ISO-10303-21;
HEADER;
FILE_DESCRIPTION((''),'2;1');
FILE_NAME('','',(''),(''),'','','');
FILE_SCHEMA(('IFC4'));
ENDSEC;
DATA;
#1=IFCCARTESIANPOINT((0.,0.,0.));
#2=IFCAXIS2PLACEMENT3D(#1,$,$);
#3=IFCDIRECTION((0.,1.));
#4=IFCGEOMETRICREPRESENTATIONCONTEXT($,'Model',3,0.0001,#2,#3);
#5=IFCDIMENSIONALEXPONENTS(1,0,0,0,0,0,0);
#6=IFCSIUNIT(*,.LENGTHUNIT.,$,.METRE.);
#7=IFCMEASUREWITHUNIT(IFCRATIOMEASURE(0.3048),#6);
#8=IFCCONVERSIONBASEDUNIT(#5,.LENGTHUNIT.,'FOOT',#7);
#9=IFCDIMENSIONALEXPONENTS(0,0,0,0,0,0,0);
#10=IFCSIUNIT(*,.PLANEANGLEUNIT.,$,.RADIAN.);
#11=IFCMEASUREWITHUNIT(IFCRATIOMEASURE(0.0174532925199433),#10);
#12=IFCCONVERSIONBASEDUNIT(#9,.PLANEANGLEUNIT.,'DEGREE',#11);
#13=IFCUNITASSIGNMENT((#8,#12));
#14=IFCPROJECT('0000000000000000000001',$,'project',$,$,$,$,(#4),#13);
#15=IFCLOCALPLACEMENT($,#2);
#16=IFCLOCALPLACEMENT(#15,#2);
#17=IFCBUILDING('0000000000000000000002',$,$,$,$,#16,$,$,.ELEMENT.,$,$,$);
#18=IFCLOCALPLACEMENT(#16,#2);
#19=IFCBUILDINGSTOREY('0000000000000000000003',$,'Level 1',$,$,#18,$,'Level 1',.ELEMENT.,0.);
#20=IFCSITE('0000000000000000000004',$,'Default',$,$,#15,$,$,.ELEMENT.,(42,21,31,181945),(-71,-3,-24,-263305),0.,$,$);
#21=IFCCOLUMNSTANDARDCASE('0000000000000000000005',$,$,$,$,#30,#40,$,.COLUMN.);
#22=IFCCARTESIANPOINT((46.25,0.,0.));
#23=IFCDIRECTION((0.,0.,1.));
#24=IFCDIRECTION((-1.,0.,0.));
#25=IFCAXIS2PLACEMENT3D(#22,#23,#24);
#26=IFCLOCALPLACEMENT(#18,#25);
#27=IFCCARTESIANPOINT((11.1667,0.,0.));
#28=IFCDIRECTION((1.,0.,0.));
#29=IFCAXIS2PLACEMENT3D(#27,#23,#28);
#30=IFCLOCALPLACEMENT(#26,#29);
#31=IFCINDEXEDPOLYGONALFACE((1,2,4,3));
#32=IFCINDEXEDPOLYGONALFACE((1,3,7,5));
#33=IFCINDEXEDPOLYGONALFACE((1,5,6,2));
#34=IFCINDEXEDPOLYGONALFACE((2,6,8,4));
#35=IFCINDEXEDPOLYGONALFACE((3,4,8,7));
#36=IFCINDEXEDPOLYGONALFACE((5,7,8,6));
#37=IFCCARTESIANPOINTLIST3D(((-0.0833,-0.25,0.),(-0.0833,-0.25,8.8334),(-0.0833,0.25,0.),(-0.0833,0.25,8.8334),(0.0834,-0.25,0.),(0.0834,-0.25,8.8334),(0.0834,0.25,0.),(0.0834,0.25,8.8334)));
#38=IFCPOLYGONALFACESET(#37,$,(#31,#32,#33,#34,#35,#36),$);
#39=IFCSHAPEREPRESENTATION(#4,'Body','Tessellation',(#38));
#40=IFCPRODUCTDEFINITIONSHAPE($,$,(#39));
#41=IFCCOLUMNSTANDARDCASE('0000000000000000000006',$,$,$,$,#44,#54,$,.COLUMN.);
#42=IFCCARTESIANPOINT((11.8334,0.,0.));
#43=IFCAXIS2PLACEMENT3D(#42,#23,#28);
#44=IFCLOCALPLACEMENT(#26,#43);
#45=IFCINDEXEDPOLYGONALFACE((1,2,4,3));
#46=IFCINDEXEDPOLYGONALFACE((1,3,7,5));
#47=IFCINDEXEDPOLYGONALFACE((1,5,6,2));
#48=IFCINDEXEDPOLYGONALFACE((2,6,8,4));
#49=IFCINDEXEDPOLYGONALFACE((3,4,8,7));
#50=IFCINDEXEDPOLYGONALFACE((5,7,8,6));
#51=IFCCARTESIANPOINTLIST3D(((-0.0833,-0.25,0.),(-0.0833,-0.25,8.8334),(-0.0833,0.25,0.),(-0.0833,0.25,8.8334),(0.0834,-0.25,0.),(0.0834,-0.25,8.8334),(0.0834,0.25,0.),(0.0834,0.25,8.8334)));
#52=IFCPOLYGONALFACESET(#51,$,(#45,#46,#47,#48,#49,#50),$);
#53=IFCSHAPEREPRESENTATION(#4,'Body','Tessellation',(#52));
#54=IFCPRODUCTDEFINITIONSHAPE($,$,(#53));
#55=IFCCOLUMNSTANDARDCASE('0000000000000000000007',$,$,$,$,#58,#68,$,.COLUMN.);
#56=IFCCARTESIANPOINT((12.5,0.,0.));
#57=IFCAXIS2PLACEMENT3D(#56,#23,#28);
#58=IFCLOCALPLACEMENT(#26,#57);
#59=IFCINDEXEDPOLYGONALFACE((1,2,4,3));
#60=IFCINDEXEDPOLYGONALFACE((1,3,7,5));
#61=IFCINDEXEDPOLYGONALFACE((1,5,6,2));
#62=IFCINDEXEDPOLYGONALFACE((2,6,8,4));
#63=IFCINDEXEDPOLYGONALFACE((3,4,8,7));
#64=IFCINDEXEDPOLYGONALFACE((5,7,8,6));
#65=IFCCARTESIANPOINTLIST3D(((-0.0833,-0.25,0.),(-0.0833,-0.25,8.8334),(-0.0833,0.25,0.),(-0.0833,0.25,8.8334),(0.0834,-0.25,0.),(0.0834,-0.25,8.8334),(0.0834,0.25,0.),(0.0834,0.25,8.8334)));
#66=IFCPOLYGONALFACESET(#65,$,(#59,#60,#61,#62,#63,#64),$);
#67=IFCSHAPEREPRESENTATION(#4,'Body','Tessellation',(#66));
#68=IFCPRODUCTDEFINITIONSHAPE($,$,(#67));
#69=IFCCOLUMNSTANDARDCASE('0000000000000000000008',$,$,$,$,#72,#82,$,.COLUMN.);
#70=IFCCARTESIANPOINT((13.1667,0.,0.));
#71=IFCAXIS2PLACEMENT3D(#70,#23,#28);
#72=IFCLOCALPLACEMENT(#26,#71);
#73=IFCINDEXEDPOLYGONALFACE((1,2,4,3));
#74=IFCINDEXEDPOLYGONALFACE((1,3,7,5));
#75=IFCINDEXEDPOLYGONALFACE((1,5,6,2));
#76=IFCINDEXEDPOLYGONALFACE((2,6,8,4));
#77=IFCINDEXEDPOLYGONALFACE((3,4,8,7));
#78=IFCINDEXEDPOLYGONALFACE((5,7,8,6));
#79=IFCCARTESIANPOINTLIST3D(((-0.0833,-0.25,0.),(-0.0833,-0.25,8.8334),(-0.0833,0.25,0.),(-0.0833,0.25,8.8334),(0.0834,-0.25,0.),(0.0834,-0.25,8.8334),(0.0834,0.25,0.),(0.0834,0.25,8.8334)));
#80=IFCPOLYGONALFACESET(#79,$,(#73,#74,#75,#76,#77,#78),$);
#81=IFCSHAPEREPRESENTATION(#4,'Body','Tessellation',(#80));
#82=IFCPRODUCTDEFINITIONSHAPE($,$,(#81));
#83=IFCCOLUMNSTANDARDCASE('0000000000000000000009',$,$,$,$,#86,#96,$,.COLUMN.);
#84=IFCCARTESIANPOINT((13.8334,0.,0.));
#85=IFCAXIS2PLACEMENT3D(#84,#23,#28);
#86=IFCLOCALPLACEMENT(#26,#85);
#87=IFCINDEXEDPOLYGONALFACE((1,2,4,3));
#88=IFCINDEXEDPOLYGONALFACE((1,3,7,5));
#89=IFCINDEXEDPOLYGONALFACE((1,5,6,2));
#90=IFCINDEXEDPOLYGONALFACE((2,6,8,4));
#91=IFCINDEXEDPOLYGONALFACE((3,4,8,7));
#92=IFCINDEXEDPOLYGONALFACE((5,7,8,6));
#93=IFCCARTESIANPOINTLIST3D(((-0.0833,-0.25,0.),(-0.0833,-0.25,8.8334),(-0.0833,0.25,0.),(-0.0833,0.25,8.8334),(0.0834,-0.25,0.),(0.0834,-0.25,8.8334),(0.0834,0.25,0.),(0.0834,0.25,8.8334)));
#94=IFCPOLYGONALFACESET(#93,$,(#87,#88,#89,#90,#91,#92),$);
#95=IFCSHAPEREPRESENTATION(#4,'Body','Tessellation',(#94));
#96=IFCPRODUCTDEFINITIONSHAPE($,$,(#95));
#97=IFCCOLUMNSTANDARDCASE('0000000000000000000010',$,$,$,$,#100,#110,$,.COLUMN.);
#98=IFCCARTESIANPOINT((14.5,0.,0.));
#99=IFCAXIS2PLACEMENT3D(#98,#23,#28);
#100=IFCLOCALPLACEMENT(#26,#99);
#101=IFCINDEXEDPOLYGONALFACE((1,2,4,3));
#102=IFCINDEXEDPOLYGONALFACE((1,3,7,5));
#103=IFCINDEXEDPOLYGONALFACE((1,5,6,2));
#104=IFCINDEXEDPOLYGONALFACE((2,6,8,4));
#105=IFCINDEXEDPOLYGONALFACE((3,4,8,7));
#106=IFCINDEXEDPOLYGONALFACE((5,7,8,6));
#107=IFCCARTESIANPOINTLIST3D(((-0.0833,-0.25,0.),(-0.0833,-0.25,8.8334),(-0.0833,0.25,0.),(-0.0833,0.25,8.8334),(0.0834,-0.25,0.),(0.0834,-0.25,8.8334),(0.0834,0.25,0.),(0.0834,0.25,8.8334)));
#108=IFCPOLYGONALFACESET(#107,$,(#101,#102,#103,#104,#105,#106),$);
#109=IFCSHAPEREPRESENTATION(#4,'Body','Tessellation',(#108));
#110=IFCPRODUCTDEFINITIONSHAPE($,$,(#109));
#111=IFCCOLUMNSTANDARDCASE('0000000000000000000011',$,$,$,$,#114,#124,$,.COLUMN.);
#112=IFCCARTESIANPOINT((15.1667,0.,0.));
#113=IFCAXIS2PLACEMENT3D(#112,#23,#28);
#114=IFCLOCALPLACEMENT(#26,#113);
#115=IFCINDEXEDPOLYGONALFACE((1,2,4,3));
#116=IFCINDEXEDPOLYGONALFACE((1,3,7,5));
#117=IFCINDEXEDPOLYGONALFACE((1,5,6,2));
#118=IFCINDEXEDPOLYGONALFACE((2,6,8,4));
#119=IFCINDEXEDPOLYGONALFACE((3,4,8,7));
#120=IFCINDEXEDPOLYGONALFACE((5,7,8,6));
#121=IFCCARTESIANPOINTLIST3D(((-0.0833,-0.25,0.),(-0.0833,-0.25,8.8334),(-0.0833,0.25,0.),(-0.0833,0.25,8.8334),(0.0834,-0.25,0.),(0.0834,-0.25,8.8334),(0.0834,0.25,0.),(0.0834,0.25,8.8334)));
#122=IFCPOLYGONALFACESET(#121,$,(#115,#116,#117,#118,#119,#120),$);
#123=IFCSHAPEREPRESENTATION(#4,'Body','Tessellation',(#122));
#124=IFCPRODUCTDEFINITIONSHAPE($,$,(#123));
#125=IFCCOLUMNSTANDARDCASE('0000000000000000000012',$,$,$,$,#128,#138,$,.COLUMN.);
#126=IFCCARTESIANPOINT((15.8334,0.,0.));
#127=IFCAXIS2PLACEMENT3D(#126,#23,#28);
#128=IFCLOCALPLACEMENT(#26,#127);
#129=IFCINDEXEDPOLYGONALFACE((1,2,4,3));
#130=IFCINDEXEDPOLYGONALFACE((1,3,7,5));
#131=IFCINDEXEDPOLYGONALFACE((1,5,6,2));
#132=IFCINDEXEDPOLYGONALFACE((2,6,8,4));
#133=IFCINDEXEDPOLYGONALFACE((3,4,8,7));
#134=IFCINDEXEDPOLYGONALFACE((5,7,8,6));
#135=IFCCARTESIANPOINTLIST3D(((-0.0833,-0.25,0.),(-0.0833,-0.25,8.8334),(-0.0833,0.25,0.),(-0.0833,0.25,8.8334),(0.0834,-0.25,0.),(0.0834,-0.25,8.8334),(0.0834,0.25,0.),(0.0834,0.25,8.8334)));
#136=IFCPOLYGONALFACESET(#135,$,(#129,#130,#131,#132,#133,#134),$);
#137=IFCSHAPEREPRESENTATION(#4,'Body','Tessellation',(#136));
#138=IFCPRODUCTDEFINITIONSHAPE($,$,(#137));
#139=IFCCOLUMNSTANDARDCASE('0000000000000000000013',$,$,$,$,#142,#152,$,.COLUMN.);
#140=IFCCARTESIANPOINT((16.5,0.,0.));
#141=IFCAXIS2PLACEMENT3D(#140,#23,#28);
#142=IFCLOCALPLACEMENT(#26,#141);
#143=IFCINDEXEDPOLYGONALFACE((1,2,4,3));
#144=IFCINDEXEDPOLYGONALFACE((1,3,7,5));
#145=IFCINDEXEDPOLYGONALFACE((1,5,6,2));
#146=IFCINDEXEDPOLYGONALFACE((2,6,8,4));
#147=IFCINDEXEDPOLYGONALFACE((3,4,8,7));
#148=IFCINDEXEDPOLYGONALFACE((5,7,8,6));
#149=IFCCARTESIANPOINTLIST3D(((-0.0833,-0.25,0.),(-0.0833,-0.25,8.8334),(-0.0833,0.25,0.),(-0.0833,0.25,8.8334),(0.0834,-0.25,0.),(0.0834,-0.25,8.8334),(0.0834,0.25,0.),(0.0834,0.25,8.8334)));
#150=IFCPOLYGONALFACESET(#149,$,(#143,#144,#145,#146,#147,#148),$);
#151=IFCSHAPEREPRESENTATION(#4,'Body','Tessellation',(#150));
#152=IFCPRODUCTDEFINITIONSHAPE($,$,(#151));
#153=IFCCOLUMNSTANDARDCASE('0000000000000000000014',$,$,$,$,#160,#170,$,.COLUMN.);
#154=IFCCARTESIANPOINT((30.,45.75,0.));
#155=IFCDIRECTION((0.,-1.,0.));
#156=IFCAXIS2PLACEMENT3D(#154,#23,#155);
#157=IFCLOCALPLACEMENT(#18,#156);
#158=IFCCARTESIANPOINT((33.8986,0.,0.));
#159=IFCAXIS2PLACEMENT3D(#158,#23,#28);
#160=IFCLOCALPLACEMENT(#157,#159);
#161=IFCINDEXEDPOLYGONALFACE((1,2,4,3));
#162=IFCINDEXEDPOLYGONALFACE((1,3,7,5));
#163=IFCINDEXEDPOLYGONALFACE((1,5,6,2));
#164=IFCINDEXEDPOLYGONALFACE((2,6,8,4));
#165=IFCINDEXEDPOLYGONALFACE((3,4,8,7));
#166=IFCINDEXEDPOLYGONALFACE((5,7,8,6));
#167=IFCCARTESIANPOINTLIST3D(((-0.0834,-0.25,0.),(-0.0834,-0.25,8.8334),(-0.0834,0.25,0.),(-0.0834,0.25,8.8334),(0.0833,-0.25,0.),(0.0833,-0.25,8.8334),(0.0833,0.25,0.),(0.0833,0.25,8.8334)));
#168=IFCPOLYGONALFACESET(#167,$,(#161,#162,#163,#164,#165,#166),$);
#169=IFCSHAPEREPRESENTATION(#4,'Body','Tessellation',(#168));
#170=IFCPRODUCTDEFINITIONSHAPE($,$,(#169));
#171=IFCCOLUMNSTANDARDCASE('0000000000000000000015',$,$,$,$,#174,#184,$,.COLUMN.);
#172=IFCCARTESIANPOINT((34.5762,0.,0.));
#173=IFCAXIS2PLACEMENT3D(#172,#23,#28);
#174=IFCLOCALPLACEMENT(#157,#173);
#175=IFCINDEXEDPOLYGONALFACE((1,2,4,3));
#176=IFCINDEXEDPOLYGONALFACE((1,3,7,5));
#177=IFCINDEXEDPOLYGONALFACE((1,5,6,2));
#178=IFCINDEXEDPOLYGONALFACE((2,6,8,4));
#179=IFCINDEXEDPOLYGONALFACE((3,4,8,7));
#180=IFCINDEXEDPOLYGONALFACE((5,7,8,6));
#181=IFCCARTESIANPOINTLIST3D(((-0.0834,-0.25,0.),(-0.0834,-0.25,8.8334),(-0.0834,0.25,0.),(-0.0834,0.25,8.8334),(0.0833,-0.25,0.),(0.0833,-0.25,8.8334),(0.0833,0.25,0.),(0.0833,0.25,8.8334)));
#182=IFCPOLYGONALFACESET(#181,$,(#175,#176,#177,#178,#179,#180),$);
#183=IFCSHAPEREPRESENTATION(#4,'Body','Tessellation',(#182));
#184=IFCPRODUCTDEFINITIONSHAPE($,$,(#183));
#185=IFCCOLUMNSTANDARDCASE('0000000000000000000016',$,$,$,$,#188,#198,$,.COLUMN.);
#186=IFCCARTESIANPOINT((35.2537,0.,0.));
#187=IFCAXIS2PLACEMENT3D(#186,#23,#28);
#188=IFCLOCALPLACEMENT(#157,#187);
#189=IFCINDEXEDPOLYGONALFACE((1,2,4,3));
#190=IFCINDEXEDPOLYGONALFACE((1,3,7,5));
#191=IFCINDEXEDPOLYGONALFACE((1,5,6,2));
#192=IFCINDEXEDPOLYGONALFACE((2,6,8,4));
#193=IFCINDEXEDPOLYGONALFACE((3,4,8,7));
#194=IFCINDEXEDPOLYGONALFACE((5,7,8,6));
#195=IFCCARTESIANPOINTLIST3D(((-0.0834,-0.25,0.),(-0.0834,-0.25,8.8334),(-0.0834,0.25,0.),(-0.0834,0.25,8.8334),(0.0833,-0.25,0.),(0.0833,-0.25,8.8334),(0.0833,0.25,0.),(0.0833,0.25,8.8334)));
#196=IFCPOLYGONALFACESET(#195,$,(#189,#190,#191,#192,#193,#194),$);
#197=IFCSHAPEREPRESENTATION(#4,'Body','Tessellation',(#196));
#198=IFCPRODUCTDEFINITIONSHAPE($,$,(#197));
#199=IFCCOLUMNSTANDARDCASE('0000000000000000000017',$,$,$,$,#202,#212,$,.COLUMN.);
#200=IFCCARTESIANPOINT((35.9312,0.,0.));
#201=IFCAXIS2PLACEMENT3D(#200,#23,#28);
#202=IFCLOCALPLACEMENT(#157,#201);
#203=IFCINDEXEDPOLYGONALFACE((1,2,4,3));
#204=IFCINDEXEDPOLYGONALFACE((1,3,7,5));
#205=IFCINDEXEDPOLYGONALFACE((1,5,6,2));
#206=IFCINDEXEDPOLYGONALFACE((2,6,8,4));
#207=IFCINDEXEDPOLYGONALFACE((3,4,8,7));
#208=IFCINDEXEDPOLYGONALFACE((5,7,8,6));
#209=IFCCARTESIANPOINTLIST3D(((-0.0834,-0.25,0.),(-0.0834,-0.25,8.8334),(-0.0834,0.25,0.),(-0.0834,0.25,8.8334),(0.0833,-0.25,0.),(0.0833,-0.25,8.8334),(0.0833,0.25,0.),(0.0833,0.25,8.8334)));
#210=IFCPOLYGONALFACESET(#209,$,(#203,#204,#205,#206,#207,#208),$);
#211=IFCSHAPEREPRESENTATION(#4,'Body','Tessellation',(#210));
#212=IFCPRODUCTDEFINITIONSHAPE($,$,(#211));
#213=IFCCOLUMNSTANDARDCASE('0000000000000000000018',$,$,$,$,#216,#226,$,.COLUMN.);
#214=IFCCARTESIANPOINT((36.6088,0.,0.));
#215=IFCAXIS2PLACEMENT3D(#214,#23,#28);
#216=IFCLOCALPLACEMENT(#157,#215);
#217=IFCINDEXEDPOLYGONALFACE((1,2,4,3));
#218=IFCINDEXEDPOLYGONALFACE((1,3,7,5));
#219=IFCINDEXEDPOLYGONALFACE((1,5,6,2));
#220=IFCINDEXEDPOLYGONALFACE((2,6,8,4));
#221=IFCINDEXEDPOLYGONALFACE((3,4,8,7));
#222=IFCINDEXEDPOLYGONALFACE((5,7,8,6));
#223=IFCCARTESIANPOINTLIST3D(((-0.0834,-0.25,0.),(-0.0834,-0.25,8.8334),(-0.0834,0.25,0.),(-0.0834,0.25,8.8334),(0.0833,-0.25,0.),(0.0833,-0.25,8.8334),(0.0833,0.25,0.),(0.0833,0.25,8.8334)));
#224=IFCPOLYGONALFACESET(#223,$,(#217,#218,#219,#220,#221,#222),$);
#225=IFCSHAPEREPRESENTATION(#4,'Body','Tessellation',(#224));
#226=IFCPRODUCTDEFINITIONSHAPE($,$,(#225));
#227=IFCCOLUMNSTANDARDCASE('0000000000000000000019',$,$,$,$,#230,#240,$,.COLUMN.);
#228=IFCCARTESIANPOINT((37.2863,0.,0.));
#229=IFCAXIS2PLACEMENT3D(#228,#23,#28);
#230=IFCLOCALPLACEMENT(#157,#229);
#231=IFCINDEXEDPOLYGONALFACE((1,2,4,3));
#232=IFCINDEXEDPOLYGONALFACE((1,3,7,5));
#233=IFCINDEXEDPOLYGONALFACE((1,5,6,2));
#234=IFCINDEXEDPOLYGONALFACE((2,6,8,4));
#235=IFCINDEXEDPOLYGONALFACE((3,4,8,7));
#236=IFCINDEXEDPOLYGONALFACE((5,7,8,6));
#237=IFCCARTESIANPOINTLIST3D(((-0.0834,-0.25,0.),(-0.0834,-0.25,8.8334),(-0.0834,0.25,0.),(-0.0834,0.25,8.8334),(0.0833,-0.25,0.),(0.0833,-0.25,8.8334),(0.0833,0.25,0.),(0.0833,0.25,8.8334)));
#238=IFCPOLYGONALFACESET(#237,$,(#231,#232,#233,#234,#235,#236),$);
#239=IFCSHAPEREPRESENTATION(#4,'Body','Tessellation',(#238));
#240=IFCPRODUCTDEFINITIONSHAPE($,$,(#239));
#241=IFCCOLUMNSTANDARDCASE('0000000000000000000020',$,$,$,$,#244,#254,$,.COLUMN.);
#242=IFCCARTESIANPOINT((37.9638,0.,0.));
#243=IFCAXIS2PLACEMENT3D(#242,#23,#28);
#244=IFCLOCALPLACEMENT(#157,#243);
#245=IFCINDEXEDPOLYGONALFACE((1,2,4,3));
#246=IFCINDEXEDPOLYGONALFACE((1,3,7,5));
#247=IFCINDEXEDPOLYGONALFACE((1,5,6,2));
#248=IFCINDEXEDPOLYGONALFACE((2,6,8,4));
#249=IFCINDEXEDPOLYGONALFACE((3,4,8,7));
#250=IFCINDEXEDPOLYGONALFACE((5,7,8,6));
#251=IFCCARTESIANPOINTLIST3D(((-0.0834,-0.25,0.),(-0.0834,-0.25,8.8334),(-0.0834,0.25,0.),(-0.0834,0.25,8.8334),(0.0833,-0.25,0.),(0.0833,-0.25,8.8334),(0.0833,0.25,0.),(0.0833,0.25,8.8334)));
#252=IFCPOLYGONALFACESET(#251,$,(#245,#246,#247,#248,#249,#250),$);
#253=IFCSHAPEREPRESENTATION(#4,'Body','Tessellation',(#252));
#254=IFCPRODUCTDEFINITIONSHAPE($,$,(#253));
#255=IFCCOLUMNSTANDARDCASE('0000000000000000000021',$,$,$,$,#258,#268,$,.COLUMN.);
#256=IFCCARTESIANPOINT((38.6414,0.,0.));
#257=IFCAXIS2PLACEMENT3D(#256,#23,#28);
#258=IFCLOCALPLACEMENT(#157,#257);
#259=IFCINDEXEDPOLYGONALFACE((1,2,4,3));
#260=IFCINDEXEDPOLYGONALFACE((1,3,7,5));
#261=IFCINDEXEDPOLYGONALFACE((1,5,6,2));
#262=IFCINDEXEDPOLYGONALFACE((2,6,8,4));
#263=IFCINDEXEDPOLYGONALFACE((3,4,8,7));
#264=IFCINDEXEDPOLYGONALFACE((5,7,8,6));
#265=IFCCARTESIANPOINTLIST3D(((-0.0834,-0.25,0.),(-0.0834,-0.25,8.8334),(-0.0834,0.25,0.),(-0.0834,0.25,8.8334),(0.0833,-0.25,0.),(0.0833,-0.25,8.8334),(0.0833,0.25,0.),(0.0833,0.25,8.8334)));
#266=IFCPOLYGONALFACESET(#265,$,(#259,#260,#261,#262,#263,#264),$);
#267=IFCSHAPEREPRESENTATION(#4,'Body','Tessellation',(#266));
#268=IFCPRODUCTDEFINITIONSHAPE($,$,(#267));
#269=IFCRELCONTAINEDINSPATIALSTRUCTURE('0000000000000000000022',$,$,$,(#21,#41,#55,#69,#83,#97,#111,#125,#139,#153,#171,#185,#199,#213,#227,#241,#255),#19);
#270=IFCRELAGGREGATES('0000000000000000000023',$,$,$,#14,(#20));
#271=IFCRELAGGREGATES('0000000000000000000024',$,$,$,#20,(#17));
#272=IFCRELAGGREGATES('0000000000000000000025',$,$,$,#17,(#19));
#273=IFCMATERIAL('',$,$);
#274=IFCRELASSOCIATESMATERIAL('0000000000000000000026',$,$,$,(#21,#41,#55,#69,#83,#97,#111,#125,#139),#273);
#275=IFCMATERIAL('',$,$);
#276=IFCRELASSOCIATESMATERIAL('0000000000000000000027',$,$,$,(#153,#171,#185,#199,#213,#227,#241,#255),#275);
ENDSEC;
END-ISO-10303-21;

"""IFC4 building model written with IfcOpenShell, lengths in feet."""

from ifc_helpers import new_model, entity, si_unit, converted_unit, direction, frame, origin, place, context, project, spatial, rectangle, extrude, material, element, save


model = new_model("IFC4")

# Units and contexts
model_context = context("Model", 3, precision=0.0001, world=origin(), true_north=direction((0.0, 1.0)))
ifc_project = project(units=[converted_unit("LENGTHUNIT", "FOOT", entity("IfcRatioMeasure", 0.3048), si_unit("LENGTHUNIT", "METRE"), dimensions=[1, 0, 0, 0, 0, 0, 0]), converted_unit("PLANEANGLEUNIT", "DEGREE", entity("IfcRatioMeasure", 0.0174532925199433), si_unit("PLANEANGLEUNIT", "RADIAN"), dimensions=[0, 0, 0, 0, 0, 0, 0])], contexts=[model_context])

# Site, building, storey
site_placement = place(None, origin())
site = spatial("IfcSite", under=ifc_project, at=site_placement, Name="Default", CompositionType="ELEMENT", RefLatitude=(42, 21, 31, 181945), RefLongitude=(-71, -3, -24, -263305), RefElevation=0.0)
building_placement = place(site_placement, origin())
building = spatial("IfcBuilding", under=site, at=building_placement, CompositionType="ELEMENT")
storey_placement = place(building_placement, origin())
storey = spatial("IfcBuildingStorey", under=building, at=storey_placement, Name="Level 1", LongName="Level 1", CompositionType="ELEMENT", Elevation=0.0)

# Columns
ifc_material_1 = material(Name="")
placement_1 = place(storey_placement, frame((46.25, 0.0, 0.0), z_axis=(0.0, 0.0, 1.0), x_axis=(-1.0, 0.0, 0.0)))
for number, where, z_axis, x_axis in (
    (1, (11.1667, 0.0, 0.0), (0.0, 0.0, 1.0), (1.0, 0.0, 0.0)),
    (2, (11.8334, 0.0, 0.0), (0.0, 0.0, 1.0), (1.0, 0.0, 0.0)),
    (3, (12.5, 0.0, 0.0), (0.0, 0.0, 1.0), (1.0, 0.0, 0.0)),
    (4, (13.1667, 0.0, 0.0), (0.0, 0.0, 1.0), (1.0, 0.0, 0.0)),
    (5, (13.8334, 0.0, 0.0), (0.0, 0.0, 1.0), (1.0, 0.0, 0.0)),
    (6, (14.5, 0.0, 0.0), (0.0, 0.0, 1.0), (1.0, 0.0, 0.0)),
    (7, (15.1667, 0.0, 0.0), (0.0, 0.0, 1.0), (1.0, 0.0, 0.0)),
    (8, (15.8334, 0.0, 0.0), (0.0, 0.0, 1.0), (1.0, 0.0, 0.0)),
    (9, (16.5, 0.0, 0.0), (0.0, 0.0, 1.0), (1.0, 0.0, 0.0)),
):
    element("IfcColumnStandardCase", number, at=place(placement_1, frame(where, z_axis=z_axis, x_axis=x_axis)), inside=storey, material=ifc_material_1, PredefinedType="COLUMN", context=model_context, shape_type="SweptSolid", body=[
        extrude(rectangle(XDim=0.1667, YDim=0.5), origin(), (0.0, 0.0, 1.0), 8.8334),
    ])
ifc_material_2 = material(Name="")
placement_2 = place(storey_placement, frame((30.0, 45.75, 0.0), z_axis=(0.0, 0.0, 1.0), x_axis=(0.0, -1.0, 0.0)))
for number, where, z_axis, x_axis in (
    (10, (33.8986, 0.0, 0.0), (0.0, 0.0, 1.0), (1.0, 0.0, 0.0)),
    (11, (34.5762, 0.0, 0.0), (0.0, 0.0, 1.0), (1.0, 0.0, 0.0)),
    (12, (35.2537, 0.0, 0.0), (0.0, 0.0, 1.0), (1.0, 0.0, 0.0)),
    (13, (35.9312, 0.0, 0.0), (0.0, 0.0, 1.0), (1.0, 0.0, 0.0)),
    (14, (36.6088, 0.0, 0.0), (0.0, 0.0, 1.0), (1.0, 0.0, 0.0)),
    (15, (37.2863, 0.0, 0.0), (0.0, 0.0, 1.0), (1.0, 0.0, 0.0)),
    (16, (37.9638, 0.0, 0.0), (0.0, 0.0, 1.0), (1.0, 0.0, 0.0)),
    (17, (38.6414, 0.0, 0.0), (0.0, 0.0, 1.0), (1.0, 0.0, 0.0)),
):
    element("IfcColumnStandardCase", number, at=place(placement_2, frame(where, z_axis=z_axis, x_axis=x_axis)), inside=storey, material=ifc_material_2, PredefinedType="COLUMN", context=model_context, shape_type="SweptSolid", body=[
        extrude(rectangle(XDim=0.1667, YDim=0.5), origin(), (0.0, 0.0, 1.0), 8.8334),
    ])

save(model, "model.ifc")
